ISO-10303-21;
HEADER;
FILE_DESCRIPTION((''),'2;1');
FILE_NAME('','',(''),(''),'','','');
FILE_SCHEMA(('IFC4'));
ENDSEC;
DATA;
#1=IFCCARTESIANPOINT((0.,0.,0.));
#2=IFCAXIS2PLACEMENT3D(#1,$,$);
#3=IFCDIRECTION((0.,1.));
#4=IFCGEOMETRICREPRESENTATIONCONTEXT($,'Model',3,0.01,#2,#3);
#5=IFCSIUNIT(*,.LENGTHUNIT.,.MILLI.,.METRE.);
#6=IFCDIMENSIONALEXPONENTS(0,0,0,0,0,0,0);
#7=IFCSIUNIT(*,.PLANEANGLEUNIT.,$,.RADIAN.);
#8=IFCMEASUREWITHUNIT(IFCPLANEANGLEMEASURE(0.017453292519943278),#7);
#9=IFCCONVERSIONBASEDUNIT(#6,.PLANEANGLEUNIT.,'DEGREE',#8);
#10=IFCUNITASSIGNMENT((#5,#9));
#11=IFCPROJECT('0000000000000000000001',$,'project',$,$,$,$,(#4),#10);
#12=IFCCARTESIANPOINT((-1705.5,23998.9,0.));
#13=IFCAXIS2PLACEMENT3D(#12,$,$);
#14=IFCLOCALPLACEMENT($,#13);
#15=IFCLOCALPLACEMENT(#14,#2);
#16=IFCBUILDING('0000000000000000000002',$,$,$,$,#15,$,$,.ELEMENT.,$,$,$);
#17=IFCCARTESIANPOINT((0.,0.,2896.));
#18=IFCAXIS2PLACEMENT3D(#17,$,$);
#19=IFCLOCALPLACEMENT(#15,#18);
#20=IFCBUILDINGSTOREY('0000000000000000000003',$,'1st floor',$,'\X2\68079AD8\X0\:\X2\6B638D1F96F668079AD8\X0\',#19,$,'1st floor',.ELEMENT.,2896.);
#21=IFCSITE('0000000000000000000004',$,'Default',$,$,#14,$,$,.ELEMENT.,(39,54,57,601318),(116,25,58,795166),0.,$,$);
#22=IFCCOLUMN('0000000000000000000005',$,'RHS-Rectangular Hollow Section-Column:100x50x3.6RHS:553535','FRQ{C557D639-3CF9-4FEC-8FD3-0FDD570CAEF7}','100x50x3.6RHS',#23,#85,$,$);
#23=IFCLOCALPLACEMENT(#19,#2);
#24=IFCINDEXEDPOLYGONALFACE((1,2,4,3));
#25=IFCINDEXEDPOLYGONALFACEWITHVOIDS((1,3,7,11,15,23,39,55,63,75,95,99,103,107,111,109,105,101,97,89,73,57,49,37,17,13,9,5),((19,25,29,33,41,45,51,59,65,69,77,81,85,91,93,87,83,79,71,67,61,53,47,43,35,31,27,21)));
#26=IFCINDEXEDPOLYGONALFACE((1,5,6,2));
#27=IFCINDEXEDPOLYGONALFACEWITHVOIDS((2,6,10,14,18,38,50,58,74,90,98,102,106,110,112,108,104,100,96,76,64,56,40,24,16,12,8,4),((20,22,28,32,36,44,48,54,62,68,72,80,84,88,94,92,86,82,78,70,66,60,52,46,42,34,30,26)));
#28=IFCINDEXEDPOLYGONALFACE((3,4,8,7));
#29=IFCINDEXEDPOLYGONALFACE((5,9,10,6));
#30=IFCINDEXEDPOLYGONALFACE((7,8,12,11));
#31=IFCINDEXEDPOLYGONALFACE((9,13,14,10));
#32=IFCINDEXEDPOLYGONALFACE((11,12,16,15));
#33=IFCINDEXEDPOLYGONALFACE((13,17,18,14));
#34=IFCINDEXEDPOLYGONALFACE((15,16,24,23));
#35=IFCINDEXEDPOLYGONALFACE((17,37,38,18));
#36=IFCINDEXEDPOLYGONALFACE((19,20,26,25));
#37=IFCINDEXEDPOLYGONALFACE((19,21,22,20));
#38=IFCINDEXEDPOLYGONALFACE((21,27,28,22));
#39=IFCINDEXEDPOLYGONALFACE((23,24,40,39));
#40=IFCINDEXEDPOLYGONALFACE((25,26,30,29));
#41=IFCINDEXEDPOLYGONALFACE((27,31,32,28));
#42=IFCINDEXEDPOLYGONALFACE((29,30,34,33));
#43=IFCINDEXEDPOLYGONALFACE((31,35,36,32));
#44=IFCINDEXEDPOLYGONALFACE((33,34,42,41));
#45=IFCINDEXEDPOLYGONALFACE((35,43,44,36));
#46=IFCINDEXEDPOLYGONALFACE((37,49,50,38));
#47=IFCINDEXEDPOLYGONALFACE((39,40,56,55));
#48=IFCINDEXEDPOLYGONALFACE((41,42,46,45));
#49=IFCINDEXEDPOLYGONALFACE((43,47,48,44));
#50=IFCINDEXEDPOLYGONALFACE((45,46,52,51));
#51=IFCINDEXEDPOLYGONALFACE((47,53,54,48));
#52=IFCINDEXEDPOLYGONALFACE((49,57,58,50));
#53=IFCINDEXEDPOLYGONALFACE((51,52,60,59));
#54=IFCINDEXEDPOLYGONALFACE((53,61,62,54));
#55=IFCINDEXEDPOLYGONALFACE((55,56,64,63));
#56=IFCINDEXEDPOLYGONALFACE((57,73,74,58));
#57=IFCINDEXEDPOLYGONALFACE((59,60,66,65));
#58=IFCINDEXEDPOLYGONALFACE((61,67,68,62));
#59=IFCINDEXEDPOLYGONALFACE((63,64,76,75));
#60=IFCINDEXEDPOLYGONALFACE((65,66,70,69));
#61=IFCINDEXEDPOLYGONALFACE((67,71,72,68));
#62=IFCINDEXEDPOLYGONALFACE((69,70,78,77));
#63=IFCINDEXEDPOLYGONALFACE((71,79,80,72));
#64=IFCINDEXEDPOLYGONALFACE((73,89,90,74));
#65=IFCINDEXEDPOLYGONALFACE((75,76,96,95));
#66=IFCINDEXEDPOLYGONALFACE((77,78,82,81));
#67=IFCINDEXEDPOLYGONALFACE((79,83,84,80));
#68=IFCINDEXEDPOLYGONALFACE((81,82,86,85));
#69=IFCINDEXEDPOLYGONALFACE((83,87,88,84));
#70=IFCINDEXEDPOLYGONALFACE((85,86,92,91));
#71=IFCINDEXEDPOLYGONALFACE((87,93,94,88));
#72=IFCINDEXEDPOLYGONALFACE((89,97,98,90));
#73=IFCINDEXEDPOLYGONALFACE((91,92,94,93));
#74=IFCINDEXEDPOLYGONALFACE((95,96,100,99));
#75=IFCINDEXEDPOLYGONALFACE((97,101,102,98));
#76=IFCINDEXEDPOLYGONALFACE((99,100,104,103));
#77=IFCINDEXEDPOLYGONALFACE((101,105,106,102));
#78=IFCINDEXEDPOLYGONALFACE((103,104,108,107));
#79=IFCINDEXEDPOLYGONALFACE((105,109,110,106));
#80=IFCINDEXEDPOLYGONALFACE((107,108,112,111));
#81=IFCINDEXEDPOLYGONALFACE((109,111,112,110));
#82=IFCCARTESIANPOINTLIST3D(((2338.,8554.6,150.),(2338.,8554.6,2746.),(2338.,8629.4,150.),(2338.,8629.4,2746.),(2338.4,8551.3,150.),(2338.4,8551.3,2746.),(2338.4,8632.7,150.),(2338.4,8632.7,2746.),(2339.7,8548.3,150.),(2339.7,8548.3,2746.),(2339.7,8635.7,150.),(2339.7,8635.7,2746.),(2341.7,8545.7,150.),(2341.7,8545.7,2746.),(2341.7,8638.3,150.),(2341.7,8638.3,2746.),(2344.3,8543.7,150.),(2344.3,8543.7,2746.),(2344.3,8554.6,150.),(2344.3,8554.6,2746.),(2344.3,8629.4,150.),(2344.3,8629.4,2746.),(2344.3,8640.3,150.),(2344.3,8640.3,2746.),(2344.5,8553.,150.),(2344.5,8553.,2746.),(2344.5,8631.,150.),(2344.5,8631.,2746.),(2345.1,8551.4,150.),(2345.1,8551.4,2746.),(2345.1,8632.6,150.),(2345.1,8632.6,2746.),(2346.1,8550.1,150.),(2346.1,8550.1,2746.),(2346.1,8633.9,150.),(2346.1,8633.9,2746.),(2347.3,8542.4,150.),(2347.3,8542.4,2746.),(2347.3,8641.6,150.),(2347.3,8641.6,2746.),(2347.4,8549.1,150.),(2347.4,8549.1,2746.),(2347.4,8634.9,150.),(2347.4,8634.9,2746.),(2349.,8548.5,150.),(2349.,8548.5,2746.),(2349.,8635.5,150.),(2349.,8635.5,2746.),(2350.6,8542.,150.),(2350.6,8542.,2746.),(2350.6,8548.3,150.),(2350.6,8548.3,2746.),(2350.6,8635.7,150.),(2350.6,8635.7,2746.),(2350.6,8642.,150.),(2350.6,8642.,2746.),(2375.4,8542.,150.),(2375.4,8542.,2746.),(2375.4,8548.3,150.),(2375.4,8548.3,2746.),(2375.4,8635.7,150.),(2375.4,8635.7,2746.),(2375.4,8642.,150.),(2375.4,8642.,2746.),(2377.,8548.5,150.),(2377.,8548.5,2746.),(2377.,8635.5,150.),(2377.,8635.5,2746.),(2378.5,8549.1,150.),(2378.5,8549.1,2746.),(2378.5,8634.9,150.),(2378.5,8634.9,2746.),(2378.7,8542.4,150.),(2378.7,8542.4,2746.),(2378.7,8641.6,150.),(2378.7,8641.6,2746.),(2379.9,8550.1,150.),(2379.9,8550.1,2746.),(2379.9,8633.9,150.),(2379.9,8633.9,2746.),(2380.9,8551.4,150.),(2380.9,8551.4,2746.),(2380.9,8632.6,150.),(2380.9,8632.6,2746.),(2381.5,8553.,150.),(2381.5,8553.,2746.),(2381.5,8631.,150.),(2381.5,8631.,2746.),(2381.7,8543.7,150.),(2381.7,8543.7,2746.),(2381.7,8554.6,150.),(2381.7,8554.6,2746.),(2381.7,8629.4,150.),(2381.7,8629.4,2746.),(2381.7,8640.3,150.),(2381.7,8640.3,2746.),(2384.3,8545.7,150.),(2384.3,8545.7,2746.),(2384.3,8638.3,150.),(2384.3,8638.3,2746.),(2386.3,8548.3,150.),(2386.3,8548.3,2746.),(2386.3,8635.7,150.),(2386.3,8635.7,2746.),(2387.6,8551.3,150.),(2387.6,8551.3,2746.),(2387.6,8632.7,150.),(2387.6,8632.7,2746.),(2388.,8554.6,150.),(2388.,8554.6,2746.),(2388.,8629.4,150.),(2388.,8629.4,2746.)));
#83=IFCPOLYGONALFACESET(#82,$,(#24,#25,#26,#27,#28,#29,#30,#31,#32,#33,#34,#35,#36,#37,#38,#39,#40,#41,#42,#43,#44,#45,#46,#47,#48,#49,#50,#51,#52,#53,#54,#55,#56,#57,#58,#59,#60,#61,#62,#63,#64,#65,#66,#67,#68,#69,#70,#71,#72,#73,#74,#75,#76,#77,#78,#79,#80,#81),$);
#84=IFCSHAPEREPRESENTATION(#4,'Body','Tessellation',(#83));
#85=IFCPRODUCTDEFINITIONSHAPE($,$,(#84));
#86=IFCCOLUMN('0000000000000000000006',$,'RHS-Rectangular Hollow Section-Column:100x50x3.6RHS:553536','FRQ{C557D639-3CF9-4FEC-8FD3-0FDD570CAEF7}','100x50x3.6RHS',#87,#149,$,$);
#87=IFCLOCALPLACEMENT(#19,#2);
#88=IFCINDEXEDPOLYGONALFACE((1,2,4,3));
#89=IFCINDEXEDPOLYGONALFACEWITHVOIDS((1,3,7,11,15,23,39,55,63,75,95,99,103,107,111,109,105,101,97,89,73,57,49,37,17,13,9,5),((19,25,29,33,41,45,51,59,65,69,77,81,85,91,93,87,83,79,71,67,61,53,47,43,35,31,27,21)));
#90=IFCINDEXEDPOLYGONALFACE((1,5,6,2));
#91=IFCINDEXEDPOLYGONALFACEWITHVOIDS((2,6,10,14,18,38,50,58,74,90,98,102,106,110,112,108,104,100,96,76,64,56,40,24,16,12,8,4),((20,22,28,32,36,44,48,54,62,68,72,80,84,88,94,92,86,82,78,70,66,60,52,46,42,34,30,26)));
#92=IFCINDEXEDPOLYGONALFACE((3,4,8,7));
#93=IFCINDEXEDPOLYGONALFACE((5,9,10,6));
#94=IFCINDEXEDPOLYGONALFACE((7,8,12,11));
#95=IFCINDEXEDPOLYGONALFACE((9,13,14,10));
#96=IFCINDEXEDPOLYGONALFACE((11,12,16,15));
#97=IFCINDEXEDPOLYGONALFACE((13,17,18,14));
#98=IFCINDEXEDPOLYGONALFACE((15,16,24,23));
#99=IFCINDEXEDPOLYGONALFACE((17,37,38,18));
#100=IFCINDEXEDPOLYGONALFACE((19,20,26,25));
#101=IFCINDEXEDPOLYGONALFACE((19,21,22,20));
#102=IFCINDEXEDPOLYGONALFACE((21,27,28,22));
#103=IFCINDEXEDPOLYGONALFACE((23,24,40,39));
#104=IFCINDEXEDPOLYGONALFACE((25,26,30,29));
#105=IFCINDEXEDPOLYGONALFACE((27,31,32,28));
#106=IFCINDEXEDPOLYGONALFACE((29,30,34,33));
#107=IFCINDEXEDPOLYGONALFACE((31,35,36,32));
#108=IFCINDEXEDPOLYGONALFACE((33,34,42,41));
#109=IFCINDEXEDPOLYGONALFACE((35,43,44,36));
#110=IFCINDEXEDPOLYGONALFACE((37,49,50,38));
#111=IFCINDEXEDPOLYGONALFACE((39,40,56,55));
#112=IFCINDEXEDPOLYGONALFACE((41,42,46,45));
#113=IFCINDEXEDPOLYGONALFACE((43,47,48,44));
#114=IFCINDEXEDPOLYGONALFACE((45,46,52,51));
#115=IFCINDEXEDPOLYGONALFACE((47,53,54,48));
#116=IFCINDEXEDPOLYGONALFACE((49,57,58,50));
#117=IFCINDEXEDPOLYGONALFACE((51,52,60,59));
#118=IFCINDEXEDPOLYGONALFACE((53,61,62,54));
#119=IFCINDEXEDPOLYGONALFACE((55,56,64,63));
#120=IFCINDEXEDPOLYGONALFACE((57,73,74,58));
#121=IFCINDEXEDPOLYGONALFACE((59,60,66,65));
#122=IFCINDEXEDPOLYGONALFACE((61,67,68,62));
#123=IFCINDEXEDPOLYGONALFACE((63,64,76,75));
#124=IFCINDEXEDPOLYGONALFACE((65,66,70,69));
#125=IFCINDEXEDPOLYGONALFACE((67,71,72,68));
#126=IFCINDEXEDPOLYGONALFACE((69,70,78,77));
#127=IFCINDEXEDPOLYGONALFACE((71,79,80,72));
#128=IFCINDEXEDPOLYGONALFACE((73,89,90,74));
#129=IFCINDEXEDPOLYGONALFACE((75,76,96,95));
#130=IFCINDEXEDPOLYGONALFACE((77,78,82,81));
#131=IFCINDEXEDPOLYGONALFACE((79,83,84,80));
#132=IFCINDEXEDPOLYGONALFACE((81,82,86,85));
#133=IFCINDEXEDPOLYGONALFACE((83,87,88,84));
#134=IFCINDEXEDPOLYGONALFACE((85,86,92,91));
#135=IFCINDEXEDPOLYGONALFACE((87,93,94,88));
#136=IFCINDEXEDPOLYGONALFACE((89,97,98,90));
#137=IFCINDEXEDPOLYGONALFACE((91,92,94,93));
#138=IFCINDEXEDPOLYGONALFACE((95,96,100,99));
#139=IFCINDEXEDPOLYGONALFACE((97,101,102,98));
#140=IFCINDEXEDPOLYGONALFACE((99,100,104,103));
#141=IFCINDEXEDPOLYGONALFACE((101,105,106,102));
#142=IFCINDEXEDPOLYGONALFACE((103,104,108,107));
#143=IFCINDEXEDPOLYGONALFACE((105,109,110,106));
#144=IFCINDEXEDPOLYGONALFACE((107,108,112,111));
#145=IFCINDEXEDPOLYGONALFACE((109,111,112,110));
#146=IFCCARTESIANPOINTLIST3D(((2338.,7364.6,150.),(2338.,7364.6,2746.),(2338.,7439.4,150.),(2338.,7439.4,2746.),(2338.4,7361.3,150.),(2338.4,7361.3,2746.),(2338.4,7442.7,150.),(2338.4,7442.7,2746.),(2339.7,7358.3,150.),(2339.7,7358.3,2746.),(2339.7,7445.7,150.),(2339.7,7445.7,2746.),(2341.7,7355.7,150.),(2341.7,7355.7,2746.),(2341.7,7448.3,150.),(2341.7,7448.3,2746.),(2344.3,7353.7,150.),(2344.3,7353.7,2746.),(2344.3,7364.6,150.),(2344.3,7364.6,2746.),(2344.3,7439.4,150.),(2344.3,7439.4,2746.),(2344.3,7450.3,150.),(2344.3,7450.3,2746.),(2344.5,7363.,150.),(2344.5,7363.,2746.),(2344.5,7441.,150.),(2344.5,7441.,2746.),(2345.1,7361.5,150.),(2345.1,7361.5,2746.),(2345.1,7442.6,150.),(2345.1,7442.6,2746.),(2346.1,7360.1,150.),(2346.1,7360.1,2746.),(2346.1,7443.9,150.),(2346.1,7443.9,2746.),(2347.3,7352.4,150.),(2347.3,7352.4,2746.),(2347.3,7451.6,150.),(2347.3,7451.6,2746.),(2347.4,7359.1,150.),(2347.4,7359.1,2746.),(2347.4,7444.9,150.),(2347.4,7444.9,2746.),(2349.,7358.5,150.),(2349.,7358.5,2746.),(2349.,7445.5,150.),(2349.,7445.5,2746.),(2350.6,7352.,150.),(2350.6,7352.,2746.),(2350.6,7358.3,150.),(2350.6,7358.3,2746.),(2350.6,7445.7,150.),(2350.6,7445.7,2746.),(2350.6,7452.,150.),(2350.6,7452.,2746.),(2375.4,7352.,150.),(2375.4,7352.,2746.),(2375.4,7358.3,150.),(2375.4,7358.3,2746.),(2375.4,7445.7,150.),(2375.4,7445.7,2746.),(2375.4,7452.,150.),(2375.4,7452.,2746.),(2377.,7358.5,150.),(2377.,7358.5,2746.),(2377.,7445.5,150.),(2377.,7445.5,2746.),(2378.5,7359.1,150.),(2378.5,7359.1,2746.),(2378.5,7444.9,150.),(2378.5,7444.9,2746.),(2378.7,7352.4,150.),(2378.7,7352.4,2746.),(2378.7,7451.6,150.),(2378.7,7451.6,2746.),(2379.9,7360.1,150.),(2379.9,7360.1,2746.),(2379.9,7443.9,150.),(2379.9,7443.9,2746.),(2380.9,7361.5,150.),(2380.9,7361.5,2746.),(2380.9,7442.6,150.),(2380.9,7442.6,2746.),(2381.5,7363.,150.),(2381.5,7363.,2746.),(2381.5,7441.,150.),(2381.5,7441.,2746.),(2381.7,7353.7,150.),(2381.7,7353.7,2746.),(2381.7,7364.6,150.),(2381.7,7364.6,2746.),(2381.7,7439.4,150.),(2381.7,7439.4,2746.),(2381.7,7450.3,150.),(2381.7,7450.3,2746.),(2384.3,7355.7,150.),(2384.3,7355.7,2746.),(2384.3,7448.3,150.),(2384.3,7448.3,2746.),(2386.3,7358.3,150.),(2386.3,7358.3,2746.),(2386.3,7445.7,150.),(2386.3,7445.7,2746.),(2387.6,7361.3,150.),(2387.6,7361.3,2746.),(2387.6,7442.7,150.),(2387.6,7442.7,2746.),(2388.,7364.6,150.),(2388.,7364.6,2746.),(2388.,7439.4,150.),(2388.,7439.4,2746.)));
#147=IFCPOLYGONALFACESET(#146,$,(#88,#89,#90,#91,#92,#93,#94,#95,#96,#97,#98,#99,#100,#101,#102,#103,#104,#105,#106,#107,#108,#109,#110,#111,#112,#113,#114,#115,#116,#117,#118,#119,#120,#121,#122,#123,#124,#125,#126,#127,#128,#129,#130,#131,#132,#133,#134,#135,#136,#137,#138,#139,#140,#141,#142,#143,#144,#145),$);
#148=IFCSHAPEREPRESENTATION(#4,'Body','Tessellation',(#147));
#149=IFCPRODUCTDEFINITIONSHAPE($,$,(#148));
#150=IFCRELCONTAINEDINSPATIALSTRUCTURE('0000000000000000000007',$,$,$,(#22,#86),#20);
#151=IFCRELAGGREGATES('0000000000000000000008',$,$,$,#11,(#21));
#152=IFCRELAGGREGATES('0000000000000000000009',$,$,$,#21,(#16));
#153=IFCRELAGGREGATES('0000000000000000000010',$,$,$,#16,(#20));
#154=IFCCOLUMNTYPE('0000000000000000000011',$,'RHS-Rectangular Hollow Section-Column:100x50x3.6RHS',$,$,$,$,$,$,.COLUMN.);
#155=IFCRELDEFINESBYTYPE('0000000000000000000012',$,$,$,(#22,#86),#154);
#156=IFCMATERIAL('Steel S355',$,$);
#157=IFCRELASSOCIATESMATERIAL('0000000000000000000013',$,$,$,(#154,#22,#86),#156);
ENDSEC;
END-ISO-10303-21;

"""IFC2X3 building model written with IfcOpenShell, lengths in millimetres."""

from ifc_helpers import new_model, entity, si_unit, converted_unit, direction, frame, origin, origin_2d, place, context, project, spatial, hollow_rectangle, extrude, clip, halfspace, material, type_object, element, save


model = new_model("IFC2X3")

# Units and contexts
model_context = context("Model", 3, precision=0.01, world=origin(), true_north=direction((0.0, 1.0)))
ifc_project = project(units=[si_unit("LENGTHUNIT", "METRE", prefix="MILLI"), converted_unit("PLANEANGLEUNIT", "DEGREE", entity("IfcPlaneAngleMeasure", 0.017453292519943278), si_unit("PLANEANGLEUNIT", "RADIAN"), dimensions=[0, 0, 0, 0, 0, 0, 0])], contexts=[model_context])

# Site, building, storey
site_placement = place(None, frame((-1705.5, 23998.9, 0.0)))
site = spatial("IfcSite", under=ifc_project, at=site_placement, Name="Default", CompositionType="ELEMENT", RefLatitude=(39, 54, 57, 601318), RefLongitude=(116, 25, 58, 795166), RefElevation=0.0)
building_placement = place(site_placement, origin())
building = spatial("IfcBuilding", under=site, at=building_placement, CompositionType="ELEMENT")
storey_placement = place(building_placement, frame((0.0, 0.0, 2896.0)))
storey = spatial("IfcBuildingStorey", under=building, at=storey_placement, Name="1st floor", ObjectType="标高:正负零标高", LongName="1st floor", CompositionType="ELEMENT", Elevation=2896.0)

# Columns
ifc_material_1 = material(Name="Steel S355")
column_type = type_object("IfcColumnType", Name="RHS-Rectangular Hollow Section-Column:100x50x3.6RHS", PredefinedType="COLUMN", material=ifc_material_1)
column_1_placement = place(storey_placement, frame((2363.0, 8592.0, 2746.0), z_axis=(0.0, 0.0, 1.0), x_axis=(-1.0, 0.0, 0.0)))
element("IfcColumn", 1, at=column_1_placement, inside=storey, type_object=column_type, material=ifc_material_1, Name="RHS-Rectangular Hollow Section-Column:100x50x3.6RHS:553535", Description="FRQ{C557D639-3CF9-4FEC-8FD3-0FDD570CAEF7}", ObjectType="100x50x3.6RHS", context=model_context, shape_type="Clipping", body=[
    clip(extrude(hollow_rectangle(XDim=50.0, YDim=100.0, WallThickness=6.3, InnerFilletRadius=6.3, OuterFilletRadius=12.6, at=origin_2d()), origin(), (0.0, 0.0, -1.0), 2651.9), halfspace(frame((2363.0, 8592.0, -2596.0), z_axis=(0.0, 0.0, 1.0), x_axis=(-1.0, 0.0, 0.0)), True)),
])
column_2_placement = place(storey_placement, frame((2363.0, 7402.0, 2746.0), z_axis=(0.0, 0.0, 1.0), x_axis=(-1.0, 0.0, 0.0)))
element("IfcColumn", 2, at=column_2_placement, inside=storey, type_object=column_type, material=ifc_material_1, Name="RHS-Rectangular Hollow Section-Column:100x50x3.6RHS:553536", Description="FRQ{C557D639-3CF9-4FEC-8FD3-0FDD570CAEF7}", ObjectType="100x50x3.6RHS", context=model_context, shape_type="Clipping", body=[
    clip(extrude(hollow_rectangle(XDim=50.0, YDim=100.0, WallThickness=6.3, InnerFilletRadius=6.3, OuterFilletRadius=12.6, at=origin_2d()), origin(), (0.0, 0.0, -1.0), 2651.9), halfspace(frame((2363.0, 7402.0, -2596.0), z_axis=(0.0, 0.0, 1.0), x_axis=(-1.0, 0.0, 0.0)), True)),
])

save(model, "model.ifc")
